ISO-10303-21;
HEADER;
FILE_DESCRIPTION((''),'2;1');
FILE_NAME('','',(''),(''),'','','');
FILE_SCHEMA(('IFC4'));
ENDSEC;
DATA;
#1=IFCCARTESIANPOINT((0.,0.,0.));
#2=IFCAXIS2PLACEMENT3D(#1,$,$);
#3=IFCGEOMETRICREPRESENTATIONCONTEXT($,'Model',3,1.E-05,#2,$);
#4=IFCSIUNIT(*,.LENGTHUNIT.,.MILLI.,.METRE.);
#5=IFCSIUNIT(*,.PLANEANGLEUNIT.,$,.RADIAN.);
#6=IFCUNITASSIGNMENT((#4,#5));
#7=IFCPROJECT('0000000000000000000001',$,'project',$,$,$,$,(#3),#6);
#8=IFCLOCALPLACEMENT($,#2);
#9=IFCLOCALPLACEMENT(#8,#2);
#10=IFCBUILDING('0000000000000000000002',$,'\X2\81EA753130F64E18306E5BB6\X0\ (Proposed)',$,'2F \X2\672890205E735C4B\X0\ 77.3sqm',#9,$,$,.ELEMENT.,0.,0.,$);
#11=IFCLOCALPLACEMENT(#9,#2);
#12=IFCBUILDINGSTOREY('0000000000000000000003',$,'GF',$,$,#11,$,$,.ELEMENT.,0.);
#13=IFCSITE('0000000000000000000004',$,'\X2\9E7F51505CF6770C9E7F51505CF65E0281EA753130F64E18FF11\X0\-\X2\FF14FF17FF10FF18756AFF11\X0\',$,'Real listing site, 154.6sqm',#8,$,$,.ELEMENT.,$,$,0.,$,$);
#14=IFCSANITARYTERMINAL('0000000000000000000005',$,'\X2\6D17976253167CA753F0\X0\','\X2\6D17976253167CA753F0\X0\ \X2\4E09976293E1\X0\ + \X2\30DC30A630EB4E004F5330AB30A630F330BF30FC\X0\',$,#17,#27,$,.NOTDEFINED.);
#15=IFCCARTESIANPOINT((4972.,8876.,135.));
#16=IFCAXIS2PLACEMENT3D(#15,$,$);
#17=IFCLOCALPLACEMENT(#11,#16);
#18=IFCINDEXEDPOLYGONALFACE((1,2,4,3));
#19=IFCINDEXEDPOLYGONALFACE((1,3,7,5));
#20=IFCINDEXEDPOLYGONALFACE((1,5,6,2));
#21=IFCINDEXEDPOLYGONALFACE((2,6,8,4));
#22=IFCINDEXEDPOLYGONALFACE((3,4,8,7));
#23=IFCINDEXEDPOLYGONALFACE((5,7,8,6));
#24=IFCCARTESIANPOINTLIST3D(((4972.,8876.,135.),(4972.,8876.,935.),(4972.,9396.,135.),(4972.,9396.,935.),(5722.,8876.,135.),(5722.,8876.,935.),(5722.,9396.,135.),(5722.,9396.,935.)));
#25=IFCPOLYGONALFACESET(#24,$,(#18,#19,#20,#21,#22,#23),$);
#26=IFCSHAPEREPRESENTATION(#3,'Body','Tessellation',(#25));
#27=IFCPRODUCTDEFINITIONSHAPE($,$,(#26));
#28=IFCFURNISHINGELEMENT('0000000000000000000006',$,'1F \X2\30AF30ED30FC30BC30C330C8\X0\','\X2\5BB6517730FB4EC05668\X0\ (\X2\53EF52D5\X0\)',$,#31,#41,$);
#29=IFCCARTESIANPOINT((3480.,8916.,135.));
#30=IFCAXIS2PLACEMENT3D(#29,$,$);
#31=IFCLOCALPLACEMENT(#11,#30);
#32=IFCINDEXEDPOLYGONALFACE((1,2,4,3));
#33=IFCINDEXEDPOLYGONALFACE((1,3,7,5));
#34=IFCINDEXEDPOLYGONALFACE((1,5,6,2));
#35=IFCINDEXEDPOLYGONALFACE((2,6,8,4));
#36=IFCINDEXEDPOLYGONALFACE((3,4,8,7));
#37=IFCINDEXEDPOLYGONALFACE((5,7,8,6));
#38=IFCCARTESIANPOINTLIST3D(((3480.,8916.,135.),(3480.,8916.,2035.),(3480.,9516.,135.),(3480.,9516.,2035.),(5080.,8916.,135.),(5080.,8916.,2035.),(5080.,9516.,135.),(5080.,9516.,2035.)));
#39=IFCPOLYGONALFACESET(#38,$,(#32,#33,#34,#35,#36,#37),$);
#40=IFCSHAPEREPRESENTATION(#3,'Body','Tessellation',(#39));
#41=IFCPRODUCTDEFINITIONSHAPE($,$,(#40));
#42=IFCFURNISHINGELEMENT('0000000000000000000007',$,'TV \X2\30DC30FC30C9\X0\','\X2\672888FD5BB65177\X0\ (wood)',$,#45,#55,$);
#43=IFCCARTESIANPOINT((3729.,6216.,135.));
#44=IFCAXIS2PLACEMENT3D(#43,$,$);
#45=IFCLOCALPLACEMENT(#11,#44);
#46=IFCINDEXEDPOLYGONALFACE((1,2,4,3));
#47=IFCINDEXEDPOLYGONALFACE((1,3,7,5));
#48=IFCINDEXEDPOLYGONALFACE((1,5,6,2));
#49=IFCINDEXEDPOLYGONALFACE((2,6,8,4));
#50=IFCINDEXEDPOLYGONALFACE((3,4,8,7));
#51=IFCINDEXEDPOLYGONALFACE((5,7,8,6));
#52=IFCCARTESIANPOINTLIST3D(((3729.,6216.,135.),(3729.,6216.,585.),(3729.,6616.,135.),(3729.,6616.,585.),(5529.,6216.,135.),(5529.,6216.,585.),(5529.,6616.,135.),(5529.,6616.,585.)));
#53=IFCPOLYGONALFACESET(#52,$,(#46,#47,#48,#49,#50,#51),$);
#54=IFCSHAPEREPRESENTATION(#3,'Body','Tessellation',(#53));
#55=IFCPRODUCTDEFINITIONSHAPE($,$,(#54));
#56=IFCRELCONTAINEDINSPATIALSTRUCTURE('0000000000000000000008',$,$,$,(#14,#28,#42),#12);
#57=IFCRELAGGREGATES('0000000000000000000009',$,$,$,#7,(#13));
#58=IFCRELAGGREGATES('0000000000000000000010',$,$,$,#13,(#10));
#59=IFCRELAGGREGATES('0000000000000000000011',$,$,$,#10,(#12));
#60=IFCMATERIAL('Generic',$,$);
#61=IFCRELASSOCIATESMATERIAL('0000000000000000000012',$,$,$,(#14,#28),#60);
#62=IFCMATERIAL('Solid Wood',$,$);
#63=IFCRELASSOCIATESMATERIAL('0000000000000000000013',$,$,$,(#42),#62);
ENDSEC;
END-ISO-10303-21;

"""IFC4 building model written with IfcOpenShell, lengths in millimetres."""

from ifc_helpers import new_model, si_unit, frame, frame_2d, origin, place, context, project, spatial, rectangle, extrude, material, element, save


model = new_model("IFC4")

# Units and contexts
model_context = context("Model", 3, precision=1e-05, world=origin())
ifc_project = project(units=[si_unit("LENGTHUNIT", "METRE", prefix="MILLI"), si_unit("PLANEANGLEUNIT", "RADIAN")], contexts=[model_context])

# Site, building, storey
site_placement = place(None, origin())
site = spatial("IfcSite", under=ifc_project, at=site_placement, Name="鹿児島県鹿児島市自由ヶ丘１-４７０８番１", ObjectType="Real listing site, 154.6sqm", CompositionType="ELEMENT", RefElevation=0.0)
building_placement = place(site_placement, origin())
building = spatial("IfcBuilding", under=site, at=building_placement, Name="自由ヶ丘の家 (Proposed)", ObjectType="2F 木造平屋 77.3sqm", CompositionType="ELEMENT", ElevationOfRefHeight=0.0, ElevationOfTerrain=0.0)
storey_placement = place(building_placement, origin())
storey = spatial("IfcBuildingStorey", under=building, at=storey_placement, Name="GF", CompositionType="ELEMENT", Elevation=0.0)

# Shared definitions
ifc_material_1 = material(Name="Solid Wood")

# Shared definitions
ifc_material_2 = material(Name="Generic")

# Sanitary terminal
sanitary_terminal_1_placement = place(storey_placement, frame((4972.0, 8876.0, 135.0)))
element("IfcSanitaryTerminal", 1, at=sanitary_terminal_1_placement, inside=storey, material=ifc_material_2, Name="洗面化粧台", Description="洗面化粧台 三面鏡 + ボウル一体カウンター", PredefinedType="NOTDEFINED", context=model_context, shape_type="SweptSolid", body=[
    extrude(rectangle(XDim=750.0, YDim=520.0, at=frame_2d((375.0, 260.0))), frame((4972.0, 8876.0, 135.0)), (0.0, 0.0, 1.0), 800.0),
])

# Furnishing elements
furnishing_1_placement = place(storey_placement, frame((3480.0, 8916.0, 135.0)))
element("IfcFurnishingElement", 2, at=furnishing_1_placement, inside=storey, material=ifc_material_2, Name="1F クローゼット", Description="家具・什器 (可動)", context=model_context, shape_type="SweptSolid", body=[
    extrude(rectangle(XDim=1600.0, YDim=600.0, at=frame_2d((800.0, 300.0))), frame((3480.0, 8916.0, 135.0)), (0.0, 0.0, 1.0), 1900.0),
])
furnishing_2_placement = place(storey_placement, frame((3729.0, 6216.0, 135.0)))
element("IfcFurnishingElement", 3, at=furnishing_2_placement, inside=storey, material=ifc_material_1, Name="TV ボード", Description="木製家具 (wood)", context=model_context, shape_type="SweptSolid", body=[
    extrude(rectangle(XDim=1800.0, YDim=400.0, at=frame_2d((900.0, 200.0))), frame((3729.0, 6216.0, 135.0)), (0.0, 0.0, 1.0), 450.0),
])

save(model, "model.ifc")
